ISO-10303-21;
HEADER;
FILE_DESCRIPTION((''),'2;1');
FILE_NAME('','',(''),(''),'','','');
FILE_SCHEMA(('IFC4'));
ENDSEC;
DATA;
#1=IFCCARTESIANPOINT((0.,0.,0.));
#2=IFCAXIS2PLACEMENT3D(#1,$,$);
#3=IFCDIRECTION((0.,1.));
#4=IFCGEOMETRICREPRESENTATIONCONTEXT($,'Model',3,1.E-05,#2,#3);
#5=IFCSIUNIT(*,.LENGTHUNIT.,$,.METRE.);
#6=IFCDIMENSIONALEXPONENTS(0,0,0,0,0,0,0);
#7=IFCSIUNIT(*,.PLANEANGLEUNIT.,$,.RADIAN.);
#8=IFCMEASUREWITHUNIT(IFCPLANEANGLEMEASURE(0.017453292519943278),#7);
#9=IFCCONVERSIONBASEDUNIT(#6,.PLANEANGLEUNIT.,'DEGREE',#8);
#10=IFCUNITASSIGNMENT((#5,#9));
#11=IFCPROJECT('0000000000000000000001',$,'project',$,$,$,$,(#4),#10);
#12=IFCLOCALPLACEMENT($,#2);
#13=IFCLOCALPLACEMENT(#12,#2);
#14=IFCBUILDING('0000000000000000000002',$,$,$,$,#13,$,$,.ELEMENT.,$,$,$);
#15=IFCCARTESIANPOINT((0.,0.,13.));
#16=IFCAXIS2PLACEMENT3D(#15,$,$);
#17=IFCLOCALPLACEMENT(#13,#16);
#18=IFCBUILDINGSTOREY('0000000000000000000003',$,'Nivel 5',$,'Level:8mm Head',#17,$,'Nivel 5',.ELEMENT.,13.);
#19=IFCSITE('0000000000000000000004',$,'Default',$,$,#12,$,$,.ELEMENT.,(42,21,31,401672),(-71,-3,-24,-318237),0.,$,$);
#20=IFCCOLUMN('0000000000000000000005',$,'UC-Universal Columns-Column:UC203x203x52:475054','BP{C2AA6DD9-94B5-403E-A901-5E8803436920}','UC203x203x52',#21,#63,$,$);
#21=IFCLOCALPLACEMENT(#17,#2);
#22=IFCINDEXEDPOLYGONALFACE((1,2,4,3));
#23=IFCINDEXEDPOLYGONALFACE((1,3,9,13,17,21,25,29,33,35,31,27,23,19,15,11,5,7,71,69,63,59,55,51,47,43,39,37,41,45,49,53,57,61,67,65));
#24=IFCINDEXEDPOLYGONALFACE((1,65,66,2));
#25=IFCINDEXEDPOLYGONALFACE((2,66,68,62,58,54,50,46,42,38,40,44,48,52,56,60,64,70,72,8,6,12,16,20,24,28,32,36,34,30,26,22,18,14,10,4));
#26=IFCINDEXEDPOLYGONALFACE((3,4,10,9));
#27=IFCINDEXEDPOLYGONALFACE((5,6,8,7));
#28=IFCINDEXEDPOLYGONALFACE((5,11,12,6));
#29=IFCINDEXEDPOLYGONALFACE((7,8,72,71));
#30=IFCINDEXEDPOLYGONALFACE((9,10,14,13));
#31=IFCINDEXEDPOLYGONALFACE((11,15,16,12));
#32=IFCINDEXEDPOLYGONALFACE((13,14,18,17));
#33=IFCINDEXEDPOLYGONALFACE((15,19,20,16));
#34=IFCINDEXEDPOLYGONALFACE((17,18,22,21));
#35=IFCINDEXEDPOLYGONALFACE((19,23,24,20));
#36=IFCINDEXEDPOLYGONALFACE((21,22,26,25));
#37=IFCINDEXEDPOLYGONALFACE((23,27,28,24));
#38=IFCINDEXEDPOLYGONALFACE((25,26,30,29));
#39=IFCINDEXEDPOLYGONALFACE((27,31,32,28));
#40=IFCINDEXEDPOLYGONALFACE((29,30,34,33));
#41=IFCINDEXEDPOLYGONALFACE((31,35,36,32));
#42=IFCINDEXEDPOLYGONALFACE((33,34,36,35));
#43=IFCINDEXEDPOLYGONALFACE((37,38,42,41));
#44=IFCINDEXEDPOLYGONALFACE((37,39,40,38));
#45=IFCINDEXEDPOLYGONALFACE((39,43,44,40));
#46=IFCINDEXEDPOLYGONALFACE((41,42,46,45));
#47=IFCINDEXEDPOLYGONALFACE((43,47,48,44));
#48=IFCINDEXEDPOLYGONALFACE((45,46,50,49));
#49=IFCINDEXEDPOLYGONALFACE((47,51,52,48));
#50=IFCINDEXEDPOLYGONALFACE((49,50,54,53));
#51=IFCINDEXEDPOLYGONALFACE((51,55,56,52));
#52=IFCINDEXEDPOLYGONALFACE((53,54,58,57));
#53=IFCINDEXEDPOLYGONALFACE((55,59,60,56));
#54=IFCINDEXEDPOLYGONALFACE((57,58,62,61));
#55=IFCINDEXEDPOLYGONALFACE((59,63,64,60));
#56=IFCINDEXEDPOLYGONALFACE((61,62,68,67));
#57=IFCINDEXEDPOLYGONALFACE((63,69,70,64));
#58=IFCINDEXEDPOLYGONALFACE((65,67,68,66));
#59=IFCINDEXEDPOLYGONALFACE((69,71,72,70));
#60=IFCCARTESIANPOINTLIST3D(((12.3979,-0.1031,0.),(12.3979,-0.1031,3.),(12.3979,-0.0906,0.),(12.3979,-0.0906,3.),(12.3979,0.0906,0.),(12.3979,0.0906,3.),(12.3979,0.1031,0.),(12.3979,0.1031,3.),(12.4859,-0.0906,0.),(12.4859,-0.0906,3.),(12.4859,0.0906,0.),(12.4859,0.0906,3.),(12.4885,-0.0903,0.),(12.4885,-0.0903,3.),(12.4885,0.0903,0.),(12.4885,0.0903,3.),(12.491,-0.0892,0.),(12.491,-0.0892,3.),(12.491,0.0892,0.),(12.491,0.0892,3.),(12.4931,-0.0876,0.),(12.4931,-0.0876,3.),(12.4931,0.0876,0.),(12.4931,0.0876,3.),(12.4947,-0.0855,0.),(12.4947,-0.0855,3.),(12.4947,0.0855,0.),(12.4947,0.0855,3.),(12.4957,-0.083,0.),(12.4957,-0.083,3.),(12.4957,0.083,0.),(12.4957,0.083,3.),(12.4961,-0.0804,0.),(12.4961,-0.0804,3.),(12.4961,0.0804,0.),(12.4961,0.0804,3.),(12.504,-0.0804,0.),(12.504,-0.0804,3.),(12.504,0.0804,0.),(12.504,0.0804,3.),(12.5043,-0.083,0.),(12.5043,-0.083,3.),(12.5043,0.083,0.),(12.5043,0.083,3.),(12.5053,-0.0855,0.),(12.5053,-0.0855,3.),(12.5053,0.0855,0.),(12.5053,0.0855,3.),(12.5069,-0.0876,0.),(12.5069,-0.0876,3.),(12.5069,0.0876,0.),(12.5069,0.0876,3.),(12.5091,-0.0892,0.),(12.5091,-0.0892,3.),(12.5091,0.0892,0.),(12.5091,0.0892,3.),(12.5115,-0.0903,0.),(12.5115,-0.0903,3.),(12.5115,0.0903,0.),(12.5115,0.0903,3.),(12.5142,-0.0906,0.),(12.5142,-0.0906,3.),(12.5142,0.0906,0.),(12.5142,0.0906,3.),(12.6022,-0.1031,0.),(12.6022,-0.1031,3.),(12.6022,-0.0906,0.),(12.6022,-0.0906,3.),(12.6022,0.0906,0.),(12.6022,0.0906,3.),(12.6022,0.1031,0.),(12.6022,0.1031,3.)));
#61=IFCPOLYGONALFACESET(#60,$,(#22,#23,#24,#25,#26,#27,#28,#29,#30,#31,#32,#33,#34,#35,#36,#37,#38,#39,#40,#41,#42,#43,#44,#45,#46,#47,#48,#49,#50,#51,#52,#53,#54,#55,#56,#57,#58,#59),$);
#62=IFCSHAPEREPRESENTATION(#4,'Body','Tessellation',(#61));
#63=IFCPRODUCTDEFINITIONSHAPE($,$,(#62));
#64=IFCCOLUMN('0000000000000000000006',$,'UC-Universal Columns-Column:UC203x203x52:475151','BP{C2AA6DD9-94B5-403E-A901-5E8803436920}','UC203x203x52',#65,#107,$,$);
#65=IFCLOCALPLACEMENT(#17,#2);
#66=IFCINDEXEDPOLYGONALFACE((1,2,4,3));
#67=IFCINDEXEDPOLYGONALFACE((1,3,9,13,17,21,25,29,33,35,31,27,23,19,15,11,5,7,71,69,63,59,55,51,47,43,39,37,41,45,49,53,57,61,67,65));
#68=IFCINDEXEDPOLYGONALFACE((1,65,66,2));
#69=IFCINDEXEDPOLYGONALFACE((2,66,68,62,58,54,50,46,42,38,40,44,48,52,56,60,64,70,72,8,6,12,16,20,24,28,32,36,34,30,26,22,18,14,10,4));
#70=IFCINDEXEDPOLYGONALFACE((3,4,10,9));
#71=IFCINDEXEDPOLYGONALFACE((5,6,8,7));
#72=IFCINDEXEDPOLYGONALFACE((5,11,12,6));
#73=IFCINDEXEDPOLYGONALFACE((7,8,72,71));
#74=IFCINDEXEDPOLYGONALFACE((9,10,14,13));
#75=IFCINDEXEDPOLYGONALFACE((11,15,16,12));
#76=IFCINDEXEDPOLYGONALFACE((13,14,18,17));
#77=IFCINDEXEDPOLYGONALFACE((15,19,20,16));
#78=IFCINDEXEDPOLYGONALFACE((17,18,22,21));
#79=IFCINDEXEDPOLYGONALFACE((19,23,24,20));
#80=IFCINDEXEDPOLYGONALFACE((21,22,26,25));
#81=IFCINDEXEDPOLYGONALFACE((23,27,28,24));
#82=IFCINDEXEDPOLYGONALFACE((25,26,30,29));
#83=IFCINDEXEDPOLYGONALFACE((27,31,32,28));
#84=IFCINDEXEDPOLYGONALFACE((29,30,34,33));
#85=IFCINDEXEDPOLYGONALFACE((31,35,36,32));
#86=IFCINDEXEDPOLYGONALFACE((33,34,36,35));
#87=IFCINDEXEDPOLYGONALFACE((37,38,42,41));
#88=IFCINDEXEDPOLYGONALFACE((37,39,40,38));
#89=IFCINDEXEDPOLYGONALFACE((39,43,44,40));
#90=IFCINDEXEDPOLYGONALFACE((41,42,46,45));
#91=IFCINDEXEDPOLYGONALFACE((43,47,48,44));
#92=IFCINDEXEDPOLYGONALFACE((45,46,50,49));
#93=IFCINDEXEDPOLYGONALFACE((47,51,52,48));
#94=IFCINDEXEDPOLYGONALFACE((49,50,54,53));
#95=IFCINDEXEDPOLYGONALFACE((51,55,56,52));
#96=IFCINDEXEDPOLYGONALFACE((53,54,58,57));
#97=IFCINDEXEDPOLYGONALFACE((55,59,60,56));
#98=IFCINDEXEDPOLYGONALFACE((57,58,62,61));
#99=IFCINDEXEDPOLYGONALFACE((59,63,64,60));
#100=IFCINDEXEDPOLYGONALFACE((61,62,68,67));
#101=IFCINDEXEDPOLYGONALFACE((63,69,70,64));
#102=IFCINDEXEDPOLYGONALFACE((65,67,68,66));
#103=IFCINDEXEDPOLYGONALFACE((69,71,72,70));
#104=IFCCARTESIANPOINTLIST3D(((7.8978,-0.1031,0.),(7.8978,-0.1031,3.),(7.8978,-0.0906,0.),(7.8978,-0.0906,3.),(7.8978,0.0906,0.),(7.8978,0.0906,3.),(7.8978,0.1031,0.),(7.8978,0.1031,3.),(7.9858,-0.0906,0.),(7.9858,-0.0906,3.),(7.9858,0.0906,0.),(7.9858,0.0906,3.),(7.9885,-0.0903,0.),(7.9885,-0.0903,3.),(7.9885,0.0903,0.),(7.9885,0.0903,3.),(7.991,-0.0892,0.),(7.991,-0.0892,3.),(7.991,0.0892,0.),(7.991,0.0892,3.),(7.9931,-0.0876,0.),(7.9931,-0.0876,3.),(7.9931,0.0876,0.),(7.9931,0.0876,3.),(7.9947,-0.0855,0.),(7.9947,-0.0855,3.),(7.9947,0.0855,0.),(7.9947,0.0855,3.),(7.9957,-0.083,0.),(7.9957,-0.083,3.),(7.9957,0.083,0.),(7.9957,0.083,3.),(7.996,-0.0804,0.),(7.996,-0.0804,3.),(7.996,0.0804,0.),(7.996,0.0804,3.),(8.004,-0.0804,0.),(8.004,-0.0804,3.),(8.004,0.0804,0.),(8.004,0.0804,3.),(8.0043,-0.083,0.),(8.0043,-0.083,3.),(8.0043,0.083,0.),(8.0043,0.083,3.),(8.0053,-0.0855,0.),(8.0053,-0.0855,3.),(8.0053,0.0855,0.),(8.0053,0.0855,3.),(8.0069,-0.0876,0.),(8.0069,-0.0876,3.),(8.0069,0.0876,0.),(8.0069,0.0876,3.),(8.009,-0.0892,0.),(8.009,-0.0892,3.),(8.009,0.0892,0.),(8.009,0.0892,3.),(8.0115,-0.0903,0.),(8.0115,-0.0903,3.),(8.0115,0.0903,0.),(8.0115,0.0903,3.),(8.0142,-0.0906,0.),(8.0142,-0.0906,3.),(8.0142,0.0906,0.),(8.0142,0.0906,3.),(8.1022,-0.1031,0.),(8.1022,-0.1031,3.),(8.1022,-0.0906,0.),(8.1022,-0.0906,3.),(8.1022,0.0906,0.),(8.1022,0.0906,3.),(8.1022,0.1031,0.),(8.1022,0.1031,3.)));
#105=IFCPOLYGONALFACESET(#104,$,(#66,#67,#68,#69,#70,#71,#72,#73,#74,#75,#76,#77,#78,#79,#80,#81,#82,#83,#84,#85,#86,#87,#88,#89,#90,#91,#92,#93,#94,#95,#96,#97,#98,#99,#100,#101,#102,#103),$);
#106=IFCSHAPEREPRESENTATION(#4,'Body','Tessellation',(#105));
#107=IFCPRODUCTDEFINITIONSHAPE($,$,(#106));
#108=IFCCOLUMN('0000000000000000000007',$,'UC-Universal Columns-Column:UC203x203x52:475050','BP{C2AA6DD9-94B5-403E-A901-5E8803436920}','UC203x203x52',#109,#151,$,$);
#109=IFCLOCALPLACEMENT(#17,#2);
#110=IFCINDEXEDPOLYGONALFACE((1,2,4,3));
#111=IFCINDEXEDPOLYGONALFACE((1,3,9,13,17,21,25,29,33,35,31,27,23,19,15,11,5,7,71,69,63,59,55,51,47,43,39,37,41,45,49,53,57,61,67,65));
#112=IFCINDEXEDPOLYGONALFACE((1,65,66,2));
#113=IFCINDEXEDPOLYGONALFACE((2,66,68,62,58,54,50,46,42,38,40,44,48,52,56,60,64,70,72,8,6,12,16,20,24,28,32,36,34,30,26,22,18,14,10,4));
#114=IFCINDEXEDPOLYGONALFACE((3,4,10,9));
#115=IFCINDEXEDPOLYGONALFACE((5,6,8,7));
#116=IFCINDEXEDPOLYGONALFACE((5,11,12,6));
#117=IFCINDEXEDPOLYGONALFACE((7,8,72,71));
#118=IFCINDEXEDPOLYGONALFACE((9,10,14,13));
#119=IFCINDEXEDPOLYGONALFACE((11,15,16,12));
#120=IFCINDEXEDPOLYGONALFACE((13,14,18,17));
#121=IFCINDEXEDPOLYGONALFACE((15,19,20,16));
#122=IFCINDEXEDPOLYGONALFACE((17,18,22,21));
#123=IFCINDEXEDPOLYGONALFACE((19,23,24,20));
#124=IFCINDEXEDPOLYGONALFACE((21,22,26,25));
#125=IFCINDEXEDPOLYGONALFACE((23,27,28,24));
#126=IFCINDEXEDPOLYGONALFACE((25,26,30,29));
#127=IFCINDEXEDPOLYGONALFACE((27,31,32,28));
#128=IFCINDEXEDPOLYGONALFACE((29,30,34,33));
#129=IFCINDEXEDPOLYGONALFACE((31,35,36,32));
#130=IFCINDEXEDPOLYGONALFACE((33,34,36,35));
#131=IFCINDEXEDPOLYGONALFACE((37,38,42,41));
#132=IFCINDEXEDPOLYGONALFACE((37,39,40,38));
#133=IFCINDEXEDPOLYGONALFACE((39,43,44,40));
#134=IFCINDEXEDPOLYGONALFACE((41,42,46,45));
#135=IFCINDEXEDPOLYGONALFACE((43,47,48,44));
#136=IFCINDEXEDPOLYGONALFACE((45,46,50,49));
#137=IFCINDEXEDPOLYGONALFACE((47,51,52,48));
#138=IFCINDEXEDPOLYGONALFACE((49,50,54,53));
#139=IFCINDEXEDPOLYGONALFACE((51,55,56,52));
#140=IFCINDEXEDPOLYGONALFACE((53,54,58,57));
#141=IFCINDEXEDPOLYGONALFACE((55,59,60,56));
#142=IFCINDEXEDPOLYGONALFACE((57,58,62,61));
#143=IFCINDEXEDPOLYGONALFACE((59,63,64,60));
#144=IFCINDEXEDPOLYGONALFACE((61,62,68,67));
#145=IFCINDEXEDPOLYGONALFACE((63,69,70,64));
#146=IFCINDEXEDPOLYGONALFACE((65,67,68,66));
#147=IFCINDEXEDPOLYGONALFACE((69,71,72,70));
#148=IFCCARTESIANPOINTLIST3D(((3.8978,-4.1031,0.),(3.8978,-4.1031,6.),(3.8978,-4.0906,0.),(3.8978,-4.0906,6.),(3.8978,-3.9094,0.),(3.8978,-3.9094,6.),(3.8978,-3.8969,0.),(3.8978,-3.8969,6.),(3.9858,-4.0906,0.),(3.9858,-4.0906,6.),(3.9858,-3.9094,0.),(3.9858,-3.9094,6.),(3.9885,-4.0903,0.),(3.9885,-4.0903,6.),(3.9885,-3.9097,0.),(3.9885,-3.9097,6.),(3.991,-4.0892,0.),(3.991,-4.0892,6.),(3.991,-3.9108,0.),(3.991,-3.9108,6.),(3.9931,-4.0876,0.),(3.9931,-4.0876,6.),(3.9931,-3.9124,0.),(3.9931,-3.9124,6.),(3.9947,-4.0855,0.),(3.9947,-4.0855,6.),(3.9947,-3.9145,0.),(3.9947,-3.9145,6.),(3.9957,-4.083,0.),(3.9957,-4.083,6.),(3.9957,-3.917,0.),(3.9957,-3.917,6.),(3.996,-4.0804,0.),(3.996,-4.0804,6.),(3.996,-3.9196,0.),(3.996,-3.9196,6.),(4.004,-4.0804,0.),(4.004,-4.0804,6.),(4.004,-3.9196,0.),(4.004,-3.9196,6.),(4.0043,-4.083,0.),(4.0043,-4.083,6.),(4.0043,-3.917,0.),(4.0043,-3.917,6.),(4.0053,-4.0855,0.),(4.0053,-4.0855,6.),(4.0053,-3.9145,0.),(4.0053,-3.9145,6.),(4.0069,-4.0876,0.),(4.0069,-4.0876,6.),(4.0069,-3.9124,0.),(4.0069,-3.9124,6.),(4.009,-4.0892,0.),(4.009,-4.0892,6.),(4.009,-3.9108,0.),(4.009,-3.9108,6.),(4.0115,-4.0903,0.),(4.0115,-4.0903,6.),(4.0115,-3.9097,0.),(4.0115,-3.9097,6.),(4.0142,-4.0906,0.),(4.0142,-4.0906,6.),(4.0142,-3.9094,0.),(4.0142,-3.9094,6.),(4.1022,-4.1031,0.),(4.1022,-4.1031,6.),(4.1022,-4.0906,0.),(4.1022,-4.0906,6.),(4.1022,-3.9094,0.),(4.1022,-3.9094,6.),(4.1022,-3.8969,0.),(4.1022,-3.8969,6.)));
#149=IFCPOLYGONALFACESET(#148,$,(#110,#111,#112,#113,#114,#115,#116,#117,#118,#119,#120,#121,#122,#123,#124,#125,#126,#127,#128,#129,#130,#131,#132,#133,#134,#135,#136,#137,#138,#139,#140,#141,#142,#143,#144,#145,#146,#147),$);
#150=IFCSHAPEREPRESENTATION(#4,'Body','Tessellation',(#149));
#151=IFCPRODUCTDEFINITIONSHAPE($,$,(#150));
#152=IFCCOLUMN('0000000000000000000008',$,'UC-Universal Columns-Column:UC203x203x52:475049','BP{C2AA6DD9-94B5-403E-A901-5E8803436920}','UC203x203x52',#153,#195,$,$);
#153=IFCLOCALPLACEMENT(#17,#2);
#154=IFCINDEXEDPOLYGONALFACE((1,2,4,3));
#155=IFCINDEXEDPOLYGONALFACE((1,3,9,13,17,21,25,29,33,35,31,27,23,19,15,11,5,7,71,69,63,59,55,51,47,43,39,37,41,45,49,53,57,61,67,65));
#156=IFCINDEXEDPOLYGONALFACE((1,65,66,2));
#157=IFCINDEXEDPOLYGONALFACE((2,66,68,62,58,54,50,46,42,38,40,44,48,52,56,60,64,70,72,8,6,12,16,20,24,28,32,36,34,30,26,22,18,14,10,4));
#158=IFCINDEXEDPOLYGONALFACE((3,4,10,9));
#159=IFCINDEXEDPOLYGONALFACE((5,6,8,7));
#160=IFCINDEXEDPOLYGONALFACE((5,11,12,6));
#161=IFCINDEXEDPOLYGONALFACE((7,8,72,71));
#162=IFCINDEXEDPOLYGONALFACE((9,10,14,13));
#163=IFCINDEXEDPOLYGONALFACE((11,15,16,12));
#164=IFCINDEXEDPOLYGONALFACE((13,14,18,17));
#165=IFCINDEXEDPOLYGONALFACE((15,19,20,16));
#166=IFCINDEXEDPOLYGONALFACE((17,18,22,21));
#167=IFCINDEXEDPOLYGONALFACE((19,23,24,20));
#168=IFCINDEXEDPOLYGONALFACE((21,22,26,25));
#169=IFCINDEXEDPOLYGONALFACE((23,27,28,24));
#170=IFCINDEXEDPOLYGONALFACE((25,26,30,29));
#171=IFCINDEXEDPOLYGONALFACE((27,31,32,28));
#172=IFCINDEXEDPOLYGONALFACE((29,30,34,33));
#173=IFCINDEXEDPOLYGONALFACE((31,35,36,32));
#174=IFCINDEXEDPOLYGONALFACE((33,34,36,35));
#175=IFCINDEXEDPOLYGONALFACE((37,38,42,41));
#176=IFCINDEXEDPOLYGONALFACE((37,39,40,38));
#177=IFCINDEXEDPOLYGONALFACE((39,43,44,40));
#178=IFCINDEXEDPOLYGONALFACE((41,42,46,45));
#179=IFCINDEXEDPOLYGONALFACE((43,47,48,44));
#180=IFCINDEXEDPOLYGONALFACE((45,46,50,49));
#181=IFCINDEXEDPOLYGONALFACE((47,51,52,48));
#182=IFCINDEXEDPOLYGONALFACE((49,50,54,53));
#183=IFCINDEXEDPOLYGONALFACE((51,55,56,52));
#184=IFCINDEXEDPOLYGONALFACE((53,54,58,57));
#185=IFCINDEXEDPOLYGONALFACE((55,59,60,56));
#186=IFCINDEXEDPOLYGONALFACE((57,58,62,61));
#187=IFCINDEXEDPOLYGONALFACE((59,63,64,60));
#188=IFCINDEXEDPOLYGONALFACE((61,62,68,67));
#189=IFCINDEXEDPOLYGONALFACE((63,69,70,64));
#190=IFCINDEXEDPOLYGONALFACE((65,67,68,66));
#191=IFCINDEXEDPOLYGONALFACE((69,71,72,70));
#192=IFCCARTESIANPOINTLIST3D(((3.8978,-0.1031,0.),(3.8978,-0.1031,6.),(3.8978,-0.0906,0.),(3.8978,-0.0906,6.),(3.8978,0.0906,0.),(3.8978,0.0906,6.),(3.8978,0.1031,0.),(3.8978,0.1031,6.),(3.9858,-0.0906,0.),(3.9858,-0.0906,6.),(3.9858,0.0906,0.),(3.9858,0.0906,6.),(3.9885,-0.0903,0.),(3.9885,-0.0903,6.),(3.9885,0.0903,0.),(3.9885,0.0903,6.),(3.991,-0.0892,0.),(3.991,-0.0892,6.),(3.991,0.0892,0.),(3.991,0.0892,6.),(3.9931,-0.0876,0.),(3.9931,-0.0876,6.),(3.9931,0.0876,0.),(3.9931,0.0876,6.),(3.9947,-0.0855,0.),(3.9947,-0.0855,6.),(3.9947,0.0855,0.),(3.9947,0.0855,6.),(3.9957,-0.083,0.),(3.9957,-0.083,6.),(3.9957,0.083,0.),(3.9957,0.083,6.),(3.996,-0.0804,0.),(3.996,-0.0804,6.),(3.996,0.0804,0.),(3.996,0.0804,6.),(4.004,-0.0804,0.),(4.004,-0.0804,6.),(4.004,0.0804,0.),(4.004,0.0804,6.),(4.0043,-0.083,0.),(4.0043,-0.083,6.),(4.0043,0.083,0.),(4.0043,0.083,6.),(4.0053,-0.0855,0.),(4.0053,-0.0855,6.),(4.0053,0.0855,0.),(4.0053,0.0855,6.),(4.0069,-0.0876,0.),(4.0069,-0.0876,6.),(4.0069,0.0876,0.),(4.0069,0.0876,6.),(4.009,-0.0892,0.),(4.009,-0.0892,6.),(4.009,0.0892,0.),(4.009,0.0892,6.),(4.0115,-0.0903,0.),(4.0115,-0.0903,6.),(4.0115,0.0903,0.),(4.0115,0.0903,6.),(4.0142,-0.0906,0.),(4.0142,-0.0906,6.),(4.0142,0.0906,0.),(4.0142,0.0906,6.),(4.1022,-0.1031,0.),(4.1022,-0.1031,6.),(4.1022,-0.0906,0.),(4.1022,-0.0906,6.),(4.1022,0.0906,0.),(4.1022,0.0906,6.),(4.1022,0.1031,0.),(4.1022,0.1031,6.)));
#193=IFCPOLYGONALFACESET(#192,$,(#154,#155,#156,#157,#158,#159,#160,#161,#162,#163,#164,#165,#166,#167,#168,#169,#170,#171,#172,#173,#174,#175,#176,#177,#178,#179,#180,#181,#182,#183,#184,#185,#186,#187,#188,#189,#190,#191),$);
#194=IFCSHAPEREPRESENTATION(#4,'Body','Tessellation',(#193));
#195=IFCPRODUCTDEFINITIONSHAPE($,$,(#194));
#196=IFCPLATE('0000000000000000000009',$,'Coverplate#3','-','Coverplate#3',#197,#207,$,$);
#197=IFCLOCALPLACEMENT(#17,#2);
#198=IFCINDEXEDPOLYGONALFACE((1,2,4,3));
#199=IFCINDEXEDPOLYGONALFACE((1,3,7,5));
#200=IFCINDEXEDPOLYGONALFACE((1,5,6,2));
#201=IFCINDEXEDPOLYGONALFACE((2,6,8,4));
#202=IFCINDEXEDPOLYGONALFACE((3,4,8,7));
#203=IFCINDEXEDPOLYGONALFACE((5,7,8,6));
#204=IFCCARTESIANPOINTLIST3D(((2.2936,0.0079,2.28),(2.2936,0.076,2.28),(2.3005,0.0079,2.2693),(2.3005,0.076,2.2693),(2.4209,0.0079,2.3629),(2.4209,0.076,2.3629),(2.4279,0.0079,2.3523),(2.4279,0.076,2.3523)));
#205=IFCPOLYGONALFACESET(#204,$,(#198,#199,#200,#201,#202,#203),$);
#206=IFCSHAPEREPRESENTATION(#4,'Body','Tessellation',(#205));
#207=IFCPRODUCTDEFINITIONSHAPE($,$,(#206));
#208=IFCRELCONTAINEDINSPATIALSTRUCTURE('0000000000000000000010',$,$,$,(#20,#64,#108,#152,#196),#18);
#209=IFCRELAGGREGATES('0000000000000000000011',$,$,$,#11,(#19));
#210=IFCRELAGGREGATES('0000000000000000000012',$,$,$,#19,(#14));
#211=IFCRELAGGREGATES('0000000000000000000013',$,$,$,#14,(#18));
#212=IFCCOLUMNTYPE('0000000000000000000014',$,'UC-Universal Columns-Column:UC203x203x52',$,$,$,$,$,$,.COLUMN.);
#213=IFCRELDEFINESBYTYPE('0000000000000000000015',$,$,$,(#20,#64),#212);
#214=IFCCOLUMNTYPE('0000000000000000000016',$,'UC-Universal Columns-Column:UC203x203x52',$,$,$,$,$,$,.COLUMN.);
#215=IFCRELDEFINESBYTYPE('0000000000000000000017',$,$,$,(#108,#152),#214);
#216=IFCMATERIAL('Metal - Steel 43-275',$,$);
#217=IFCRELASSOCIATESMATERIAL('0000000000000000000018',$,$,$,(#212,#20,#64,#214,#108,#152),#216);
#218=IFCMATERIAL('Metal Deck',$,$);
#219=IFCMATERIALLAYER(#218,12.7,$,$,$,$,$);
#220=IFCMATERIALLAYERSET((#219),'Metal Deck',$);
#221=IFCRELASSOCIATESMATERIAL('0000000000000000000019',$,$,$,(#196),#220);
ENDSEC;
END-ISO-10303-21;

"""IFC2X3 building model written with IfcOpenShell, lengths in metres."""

from ifc_helpers import new_model, entity, si_unit, converted_unit, direction, frame, origin, origin_with_axes, origin_2d, place, context, project, spatial, polyline, i_section, outline, extrude, material, layer, layer_set, type_object, element, save


model = new_model("IFC2X3")

# Units and contexts
model_context = context("Model", 3, precision=1e-05, world=origin(), true_north=direction((0.0, 1.0)))
ifc_project = project(units=[si_unit("LENGTHUNIT", "METRE"), converted_unit("PLANEANGLEUNIT", "DEGREE", entity("IfcPlaneAngleMeasure", 0.017453292519943278), si_unit("PLANEANGLEUNIT", "RADIAN"), dimensions=[0, 0, 0, 0, 0, 0, 0])], contexts=[model_context])

# Site, building, storey
site_placement = place(None, origin())
site = spatial("IfcSite", under=ifc_project, at=site_placement, Name="Default", CompositionType="ELEMENT", RefLatitude=(42, 21, 31, 401672), RefLongitude=(-71, -3, -24, -318237), RefElevation=0.0)
building_placement = place(site_placement, origin())
building = spatial("IfcBuilding", under=site, at=building_placement, CompositionType="ELEMENT")
storey_placement = place(building_placement, frame((0.0, 0.0, 13.0)))
storey = spatial("IfcBuildingStorey", under=building, at=storey_placement, Name="Nivel 5", ObjectType="Level:8mm Head", LongName="Nivel 5", CompositionType="ELEMENT", Elevation=13.0)

# Columns
ifc_material_1 = material(Name="Metal - Steel 43-275")
column_type_1 = type_object("IfcColumnType", Name="UC-Universal Columns-Column:UC203x203x52", PredefinedType="COLUMN", material=ifc_material_1)
for number, where, name in (
    (1, (12.5, 0.0, 3.0), "UC-Universal Columns-Column:UC203x203x52:475054"),
    (2, (8.0, 0.0, 3.0), "UC-Universal Columns-Column:UC203x203x52:475151"),
):
    element("IfcColumn", number, at=place(storey_placement, frame(where)), inside=storey, type_object=column_type_1, material=ifc_material_1, Name=name, Description="BP{C2AA6DD9-94B5-403E-A901-5E8803436920}", ObjectType="UC203x203x52", context=model_context, shape_type="SweptSolid", body=[
        extrude(i_section(OverallWidth=0.2043, OverallDepth=0.2062, WebThickness=0.0079, FlangeThickness=0.0125, FilletRadius=0.0102, at=origin_2d()), origin(), (0.0, 0.0, -1.0), 3.0),
    ])
column_type_2 = type_object("IfcColumnType", Name="UC-Universal Columns-Column:UC203x203x52", PredefinedType="COLUMN", material=ifc_material_1)
for number, where, name in (
    (3, (4.0, -4.0, 6.0), "UC-Universal Columns-Column:UC203x203x52:475050"),
    (4, (4.0, 0.0, 6.0), "UC-Universal Columns-Column:UC203x203x52:475049"),
):
    element("IfcColumn", number, at=place(storey_placement, frame(where)), inside=storey, type_object=column_type_2, material=ifc_material_1, Name=name, Description="BP{C2AA6DD9-94B5-403E-A901-5E8803436920}", ObjectType="UC203x203x52", context=model_context, shape_type="SweptSolid", body=[
        extrude(i_section(OverallWidth=0.2043, OverallDepth=0.2062, WebThickness=0.0079, FlangeThickness=0.0125, FilletRadius=0.0102, at=origin_2d()), origin(), (0.0, 0.0, -1.0), 6.0),
    ])

# Shared definitions
ifc_material_2 = material(Name="Metal Deck")
ifc_layer = layer(ifc_material_2, 12.7)
ifc_layer_set = layer_set([ifc_layer], Name="Metal Deck")

# Plate
plate_1_placement = place(storey_placement, frame((2.2936, 0.076, 2.28), z_axis=(0.545876, 0.0, -0.837866), x_axis=(0.837866, 0.0, 0.545876)))
element("IfcPlate", 5, at=plate_1_placement, inside=storey, material=ifc_layer_set, Name="Coverplate#3", Description="-", ObjectType="Coverplate#3", context=model_context, shape_type="SweptSolid", body=[
    extrude(outline(polyline([(0.0, 0.0), (0.152, 0.0), (0.152, 0.0681), (0.0, 0.0681), (0.0, 0.0)])), origin_with_axes(), (0.0, 0.0, 1.0), 0.0127),
])

save(model, "model.ifc")
